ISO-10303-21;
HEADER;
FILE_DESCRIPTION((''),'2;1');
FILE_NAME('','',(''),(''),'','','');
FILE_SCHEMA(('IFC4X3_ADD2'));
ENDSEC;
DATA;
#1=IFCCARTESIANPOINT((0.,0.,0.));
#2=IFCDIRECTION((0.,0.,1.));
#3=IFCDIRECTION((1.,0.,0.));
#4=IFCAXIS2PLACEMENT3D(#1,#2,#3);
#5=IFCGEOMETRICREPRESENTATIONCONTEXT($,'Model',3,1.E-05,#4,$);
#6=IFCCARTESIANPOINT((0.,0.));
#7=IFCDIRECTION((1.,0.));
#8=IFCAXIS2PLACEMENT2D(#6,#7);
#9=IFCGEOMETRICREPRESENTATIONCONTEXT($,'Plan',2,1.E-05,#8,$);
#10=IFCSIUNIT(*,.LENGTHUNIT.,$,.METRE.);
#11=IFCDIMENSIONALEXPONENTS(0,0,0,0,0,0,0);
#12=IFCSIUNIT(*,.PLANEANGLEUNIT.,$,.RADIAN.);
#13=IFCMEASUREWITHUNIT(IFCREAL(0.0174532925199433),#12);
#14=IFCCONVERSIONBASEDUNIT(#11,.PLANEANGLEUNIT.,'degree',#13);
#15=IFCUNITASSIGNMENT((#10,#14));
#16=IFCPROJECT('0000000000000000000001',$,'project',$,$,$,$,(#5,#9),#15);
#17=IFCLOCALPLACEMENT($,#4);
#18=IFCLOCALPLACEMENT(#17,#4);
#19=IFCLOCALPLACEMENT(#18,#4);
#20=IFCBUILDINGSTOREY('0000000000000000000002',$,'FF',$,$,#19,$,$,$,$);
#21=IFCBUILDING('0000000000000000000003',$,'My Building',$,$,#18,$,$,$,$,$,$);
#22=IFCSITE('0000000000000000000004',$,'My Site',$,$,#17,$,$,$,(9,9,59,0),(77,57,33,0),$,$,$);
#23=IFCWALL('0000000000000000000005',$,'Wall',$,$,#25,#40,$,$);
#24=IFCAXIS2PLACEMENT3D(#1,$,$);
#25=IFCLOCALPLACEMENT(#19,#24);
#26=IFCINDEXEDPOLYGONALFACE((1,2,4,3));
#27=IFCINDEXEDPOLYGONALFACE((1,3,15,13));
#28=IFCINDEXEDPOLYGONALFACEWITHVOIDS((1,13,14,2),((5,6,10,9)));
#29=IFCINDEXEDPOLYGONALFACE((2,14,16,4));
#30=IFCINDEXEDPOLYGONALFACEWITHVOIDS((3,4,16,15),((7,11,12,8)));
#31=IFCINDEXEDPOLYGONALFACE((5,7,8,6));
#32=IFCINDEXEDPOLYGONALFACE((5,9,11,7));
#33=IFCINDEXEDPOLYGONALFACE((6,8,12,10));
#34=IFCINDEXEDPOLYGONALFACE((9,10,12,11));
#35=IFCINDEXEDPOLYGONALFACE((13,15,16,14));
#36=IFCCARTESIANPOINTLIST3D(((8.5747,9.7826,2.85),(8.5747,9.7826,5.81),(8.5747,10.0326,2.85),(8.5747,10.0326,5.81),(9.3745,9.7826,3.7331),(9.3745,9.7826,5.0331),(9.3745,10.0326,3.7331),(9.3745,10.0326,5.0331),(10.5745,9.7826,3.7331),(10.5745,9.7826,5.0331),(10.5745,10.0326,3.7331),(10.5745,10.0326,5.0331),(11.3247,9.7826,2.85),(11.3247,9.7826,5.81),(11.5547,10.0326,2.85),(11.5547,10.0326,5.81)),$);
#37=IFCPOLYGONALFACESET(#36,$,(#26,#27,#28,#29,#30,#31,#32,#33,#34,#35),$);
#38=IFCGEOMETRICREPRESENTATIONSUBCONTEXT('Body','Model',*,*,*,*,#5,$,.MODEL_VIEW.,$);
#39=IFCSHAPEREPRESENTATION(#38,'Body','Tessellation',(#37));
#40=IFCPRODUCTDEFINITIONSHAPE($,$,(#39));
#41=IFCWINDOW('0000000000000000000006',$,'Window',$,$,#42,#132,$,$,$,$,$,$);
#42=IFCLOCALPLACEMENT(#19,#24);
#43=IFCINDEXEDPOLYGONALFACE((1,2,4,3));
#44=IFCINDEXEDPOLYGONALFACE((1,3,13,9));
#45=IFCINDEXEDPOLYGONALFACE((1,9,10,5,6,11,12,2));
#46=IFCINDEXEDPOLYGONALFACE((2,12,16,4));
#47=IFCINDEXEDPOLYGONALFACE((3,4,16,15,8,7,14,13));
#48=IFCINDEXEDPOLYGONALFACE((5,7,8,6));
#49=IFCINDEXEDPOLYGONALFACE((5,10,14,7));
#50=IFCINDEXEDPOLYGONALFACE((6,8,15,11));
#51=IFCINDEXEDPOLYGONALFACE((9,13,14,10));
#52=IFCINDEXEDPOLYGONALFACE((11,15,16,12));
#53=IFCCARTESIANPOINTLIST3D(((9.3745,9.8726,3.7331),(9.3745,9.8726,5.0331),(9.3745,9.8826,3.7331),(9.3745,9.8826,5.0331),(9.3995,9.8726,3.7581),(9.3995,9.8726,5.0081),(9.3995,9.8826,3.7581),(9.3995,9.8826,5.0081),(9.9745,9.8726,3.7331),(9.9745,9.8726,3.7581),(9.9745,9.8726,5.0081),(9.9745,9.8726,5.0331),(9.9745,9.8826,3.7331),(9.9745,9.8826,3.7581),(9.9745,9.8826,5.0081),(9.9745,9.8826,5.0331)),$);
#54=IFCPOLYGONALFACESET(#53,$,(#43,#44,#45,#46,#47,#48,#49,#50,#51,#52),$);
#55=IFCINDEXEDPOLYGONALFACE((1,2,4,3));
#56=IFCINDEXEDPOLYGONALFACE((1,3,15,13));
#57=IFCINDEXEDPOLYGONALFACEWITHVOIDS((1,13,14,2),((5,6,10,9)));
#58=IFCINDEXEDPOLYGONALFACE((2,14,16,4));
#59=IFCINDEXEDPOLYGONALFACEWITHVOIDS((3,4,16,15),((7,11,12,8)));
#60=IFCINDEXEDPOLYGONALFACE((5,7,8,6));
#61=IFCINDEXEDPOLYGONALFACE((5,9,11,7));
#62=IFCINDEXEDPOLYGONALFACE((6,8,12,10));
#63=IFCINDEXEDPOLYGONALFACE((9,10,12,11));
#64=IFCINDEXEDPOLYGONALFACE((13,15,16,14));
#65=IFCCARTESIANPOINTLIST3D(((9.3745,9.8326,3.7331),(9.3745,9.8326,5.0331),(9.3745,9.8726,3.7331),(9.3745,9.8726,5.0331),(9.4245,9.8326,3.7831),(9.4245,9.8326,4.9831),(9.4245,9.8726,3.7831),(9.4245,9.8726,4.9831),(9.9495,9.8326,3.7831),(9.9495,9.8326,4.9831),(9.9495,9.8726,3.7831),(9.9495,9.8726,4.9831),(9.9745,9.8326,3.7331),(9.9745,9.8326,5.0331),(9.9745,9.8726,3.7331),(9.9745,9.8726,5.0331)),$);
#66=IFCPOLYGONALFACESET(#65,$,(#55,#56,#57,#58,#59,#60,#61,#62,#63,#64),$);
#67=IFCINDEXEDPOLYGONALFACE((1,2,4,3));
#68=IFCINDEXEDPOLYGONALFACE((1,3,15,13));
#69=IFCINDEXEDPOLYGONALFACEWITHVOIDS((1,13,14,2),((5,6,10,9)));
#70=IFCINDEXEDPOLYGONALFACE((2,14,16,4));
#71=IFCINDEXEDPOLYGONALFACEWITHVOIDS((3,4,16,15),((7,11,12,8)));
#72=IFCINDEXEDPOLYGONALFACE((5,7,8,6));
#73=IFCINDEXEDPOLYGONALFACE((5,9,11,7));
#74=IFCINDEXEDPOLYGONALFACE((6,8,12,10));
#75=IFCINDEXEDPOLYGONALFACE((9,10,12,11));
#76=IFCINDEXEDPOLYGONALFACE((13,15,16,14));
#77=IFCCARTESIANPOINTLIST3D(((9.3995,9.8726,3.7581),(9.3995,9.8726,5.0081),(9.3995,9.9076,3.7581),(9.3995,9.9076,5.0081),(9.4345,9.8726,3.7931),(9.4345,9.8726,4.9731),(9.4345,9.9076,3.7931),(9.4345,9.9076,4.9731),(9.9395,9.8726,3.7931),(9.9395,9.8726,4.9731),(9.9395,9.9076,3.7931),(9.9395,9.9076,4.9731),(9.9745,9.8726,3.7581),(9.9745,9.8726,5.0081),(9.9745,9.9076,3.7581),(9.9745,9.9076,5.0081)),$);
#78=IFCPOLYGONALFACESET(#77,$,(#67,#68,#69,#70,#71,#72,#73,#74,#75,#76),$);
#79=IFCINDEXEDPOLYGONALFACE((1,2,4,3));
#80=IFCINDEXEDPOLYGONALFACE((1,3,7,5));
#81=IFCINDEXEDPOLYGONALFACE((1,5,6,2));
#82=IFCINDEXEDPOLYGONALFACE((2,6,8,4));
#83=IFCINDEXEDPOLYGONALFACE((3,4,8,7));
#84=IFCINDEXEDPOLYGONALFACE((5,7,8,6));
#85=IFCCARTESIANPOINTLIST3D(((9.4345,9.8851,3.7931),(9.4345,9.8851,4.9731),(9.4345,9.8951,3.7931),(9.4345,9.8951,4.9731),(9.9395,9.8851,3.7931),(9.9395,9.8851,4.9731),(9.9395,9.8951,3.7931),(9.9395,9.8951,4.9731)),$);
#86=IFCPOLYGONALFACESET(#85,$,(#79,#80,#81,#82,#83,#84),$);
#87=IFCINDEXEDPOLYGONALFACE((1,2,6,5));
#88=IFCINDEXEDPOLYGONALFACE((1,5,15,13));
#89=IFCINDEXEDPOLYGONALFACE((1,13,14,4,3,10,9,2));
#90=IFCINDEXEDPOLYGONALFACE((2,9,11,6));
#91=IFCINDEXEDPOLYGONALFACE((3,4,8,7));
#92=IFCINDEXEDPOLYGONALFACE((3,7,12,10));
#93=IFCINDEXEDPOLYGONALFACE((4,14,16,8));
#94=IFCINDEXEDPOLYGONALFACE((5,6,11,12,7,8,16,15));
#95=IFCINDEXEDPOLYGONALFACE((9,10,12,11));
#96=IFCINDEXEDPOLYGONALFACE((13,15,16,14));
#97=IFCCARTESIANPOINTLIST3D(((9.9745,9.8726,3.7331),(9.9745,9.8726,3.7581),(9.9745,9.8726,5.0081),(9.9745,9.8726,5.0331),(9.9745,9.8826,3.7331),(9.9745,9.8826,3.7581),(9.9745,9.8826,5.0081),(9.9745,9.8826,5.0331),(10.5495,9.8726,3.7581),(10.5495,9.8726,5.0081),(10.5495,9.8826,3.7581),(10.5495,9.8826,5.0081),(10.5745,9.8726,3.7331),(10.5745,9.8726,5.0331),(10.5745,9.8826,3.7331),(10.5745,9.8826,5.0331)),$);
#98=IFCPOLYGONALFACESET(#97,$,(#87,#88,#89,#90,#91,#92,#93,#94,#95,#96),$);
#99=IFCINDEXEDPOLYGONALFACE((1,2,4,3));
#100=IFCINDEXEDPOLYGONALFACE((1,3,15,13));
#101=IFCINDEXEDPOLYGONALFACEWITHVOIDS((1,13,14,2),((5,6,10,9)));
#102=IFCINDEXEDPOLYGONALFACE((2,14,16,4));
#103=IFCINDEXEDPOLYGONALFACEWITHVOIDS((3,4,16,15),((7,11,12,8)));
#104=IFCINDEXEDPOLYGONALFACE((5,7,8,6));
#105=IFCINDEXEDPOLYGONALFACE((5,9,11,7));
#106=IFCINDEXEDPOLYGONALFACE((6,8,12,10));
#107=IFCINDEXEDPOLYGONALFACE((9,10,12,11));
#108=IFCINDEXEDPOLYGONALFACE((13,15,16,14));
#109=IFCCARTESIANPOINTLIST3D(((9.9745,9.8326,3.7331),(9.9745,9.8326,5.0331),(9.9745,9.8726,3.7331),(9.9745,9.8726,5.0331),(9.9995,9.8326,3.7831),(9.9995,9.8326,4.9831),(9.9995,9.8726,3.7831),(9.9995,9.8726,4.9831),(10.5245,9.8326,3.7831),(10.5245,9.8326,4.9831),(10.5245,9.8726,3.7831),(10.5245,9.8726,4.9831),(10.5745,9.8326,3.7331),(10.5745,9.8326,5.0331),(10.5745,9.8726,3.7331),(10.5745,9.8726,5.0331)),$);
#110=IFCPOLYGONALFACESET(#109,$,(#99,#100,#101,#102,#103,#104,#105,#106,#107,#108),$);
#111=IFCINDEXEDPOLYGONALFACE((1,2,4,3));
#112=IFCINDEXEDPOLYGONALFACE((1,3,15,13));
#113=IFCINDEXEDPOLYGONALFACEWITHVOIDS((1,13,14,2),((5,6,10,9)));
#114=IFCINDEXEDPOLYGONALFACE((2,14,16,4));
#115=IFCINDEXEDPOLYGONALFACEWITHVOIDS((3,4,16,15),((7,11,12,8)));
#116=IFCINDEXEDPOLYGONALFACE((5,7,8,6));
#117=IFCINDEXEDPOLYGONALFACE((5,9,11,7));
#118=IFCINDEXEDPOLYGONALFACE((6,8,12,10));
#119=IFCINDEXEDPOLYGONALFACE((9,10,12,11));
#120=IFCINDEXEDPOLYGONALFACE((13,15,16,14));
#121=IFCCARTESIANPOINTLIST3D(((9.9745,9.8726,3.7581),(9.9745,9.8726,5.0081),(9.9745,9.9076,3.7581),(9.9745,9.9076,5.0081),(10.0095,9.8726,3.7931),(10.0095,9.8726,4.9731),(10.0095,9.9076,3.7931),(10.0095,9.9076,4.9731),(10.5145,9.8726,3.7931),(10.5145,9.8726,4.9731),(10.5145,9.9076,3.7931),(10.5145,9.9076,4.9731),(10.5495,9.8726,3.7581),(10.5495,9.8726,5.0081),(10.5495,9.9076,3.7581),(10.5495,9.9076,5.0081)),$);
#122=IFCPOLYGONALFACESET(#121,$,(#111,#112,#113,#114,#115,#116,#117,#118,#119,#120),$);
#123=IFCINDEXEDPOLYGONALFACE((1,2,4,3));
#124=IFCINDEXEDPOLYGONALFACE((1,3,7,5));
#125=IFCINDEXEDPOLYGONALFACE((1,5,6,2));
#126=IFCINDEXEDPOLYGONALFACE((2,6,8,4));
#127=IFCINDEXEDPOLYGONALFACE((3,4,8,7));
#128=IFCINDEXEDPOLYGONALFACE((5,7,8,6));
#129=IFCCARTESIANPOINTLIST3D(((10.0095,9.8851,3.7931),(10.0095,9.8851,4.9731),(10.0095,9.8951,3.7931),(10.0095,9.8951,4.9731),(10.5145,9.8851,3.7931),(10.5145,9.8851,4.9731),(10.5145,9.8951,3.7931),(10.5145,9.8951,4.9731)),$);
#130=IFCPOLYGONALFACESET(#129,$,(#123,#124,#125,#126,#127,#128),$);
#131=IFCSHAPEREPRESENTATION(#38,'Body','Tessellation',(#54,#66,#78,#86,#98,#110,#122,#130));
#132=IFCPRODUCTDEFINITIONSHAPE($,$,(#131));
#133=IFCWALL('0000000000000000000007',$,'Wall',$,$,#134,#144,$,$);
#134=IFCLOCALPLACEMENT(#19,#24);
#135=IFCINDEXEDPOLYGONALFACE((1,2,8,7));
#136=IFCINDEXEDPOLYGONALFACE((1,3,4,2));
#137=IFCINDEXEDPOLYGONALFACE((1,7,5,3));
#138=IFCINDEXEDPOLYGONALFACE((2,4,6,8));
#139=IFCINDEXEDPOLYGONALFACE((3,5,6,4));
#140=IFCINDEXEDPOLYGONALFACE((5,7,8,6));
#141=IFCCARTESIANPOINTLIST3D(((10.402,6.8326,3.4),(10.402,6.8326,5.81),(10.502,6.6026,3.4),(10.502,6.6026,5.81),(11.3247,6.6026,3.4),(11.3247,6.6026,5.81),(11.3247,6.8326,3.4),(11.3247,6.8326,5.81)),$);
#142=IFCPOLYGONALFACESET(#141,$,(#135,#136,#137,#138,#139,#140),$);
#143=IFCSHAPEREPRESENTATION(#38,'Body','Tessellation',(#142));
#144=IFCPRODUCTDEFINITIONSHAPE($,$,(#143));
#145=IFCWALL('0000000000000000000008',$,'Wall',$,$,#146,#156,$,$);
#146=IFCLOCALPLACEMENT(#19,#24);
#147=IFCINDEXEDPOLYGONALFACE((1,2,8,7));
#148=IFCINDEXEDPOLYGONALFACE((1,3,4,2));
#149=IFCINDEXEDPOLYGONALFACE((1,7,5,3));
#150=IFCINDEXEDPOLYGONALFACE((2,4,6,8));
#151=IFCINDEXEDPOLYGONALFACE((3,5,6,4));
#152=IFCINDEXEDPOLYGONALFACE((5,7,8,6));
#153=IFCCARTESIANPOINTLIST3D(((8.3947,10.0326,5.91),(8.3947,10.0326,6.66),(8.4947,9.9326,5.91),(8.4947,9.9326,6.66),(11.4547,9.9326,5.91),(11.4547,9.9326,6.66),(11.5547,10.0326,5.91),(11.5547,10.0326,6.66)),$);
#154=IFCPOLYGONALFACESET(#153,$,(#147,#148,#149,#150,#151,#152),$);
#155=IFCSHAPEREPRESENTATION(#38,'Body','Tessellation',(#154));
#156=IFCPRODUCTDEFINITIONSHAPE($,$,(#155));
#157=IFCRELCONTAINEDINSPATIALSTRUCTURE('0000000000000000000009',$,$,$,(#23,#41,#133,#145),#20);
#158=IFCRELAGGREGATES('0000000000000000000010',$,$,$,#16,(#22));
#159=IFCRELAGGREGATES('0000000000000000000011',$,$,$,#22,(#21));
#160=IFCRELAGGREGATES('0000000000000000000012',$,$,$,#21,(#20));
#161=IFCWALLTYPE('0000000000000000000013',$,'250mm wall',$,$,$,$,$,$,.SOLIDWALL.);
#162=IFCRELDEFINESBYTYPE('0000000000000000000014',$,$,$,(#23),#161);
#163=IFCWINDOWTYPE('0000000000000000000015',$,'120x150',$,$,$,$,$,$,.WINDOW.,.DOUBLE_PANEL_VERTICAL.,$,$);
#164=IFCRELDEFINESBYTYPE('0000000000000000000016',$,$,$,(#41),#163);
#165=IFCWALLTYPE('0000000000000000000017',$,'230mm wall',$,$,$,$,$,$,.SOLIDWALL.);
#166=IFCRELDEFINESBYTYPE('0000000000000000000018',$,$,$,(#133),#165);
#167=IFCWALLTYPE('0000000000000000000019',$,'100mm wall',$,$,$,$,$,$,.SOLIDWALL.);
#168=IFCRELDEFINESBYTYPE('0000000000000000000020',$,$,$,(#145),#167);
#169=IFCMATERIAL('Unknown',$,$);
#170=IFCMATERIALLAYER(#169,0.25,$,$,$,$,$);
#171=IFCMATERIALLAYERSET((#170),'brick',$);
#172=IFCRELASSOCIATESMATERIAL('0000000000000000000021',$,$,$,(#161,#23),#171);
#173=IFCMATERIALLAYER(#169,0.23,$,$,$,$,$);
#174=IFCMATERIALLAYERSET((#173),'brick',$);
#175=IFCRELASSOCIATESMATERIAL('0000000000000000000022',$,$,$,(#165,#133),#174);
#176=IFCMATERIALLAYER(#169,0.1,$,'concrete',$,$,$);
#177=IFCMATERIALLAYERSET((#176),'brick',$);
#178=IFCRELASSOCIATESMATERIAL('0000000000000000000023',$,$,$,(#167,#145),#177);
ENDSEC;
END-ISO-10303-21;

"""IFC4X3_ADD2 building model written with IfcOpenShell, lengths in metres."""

from ifc_helpers import new_model, entity, si_unit, converted_unit, frame, origin_with_axes, origin_2d_with_axis, place, context, subcontext, project, spatial, line, indexed_curve, outline, extrude, shape, source, transform, mapped, material, layer, layer_set, layer_usage, type_object, type_shapes, element, fill, save


model = new_model("IFC4X3_ADD2")

# Units and contexts
model_context = context("Model", 3, precision=1e-05, world=origin_with_axes())
plan_context = context("Plan", 2, precision=1e-05, world=origin_2d_with_axis())
body_context_1 = subcontext(model_context, "Body", "Model", "MODEL_VIEW")
body_context_2 = subcontext(plan_context, "Body", "Plan", "PLAN_VIEW")
ifc_project = project(units=[si_unit("LENGTHUNIT", "METRE"), converted_unit("PLANEANGLEUNIT", "degree", entity("IfcReal", 0.0174532925199433), si_unit("PLANEANGLEUNIT", "RADIAN"), dimensions=[0, 0, 0, 0, 0, 0, 0])], contexts=[model_context, plan_context])

# Site, building, storey
site_placement = place(None, origin_with_axes())
site = spatial("IfcSite", under=ifc_project, at=site_placement, Name="My Site", RefLatitude=(9, 9, 59, 0), RefLongitude=(77, 57, 33, 0))
building_placement = place(site_placement, origin_with_axes())
building = spatial("IfcBuilding", under=site, at=building_placement, Name="My Building")
storey_placement = place(building_placement, origin_with_axes())
storey = spatial("IfcBuildingStorey", under=building, at=storey_placement, Name="FF")

# Shared definitions
ifc_material = material(Name="Unknown")

# Wall, opening, window
ifc_layer_1 = layer(ifc_material, 0.25)
ifc_layer_set_1 = layer_set([ifc_layer_1], Name="brick")
ifc_layer_usage_1 = layer_usage(ifc_layer_set_1, "AXIS2", "POSITIVE", 0.0)
wall_type_1 = type_object("IfcWallType", Name="250mm wall", PredefinedType="SOLIDWALL", material=ifc_layer_set_1)
wall_1_placement = place(storey_placement, frame((8.5747, 9.7826, 2.85), z_axis=(0.0, 0.0, 1.0), x_axis=(1.0, 0.0, 0.0)))
wall_1 = element("IfcWall", 1, at=wall_1_placement, inside=storey, type_object=wall_type_1, material=ifc_layer_usage_1, Name="Wall", context=body_context_1, shape_type="SweptSolid", body=[
    extrude(outline(indexed_curve([(0.0, 0.0), (0.0, 0.25), (2.98, 0.25), (2.75, 0.0)], segments=[line(1, 2, 3, 4, 1)])), origin_with_axes(), (0.0, 0.0, 1.0), 2.96),
])
shared_shape_1 = source(origin_with_axes(), body_context_1, "Body", "SweptSolid", [
    extrude(outline(indexed_curve([(0.0, 0.0), (1.2, 0.0), (1.2, 1.3), (0.0, 1.3)], segments=[line(1, 2, 3, 4, 1)])), frame((0.0, -0.6, 0.0), z_axis=(0.0, -1.0, 0.0), x_axis=(1.0, 0.0, 0.0)), (0.0, 0.0, -1.0), 1.2),
])
opening_1_placement = place(wall_1_placement, frame((0.7998, 0.0, 0.8831), z_axis=(0.0, 0.0, 1.0), x_axis=(1.0, 0.0, 0.0)))
opening_1 = element("IfcOpeningElement", 2, at=opening_1_placement, cuts=wall_1, PredefinedType="OPENING", context=body_context_1, shape_type="MappedRepresentation", body=[
    mapped(shared_shape_1, transform((0.0, 0.0, 0.0), x_axis=(1.0, 0.0, 0.0), y_axis=(0.0, 1.0, 0.0), z_axis=(0.0, 0.0, 1.0), scale=1.0)),
])
window_type = type_object("IfcWindowType", Name="120x150", PartitioningType="DOUBLE_PANEL_VERTICAL", PredefinedType="WINDOW")
shared_shape_2 = source(origin_with_axes(), body_context_1, "Body", "SweptSolid", [
    extrude(outline(indexed_curve([(0.6, 0.0), (0.0, 0.0), (0.0, 1.3), (0.6, 1.3), (0.6, 1.275), (0.025, 1.275), (0.025, 0.025), (0.6, 0.025)], segments=[line(1, 2, 3, 4, 5, 6, 7, 8, 1)])), frame((0.0, 0.09, 0.0), z_axis=(0.0, -1.0, 0.0), x_axis=(1.0, 0.0, 0.0)), (0.0, 0.0, -1.0), 0.01),
    extrude(outline(indexed_curve([(0.0, 0.0), (0.6, 0.0), (0.6, 1.3), (0.0, 1.3)], segments=[line(1, 2, 3, 4, 1)]), holes=[indexed_curve([(0.05, 0.05), (0.575, 0.05), (0.575, 1.25), (0.05, 1.25)], segments=[line(1, 2, 3, 4, 1)])]), frame((0.0, 0.05, 0.0), z_axis=(0.0, -1.0, 0.0), x_axis=(1.0, 0.0, 0.0)), (0.0, 0.0, -1.0), 0.04),
    extrude(outline(indexed_curve([(0.0, 0.0), (0.575, 0.0), (0.575, 1.25), (0.0, 1.25)], segments=[line(1, 2, 3, 4, 1)]), holes=[indexed_curve([(0.035, 0.035), (0.54, 0.035), (0.54, 1.215), (0.035, 1.215)], segments=[line(1, 2, 3, 4, 1)])]), frame((0.025, 0.09, 0.025), z_axis=(0.0, -1.0, 0.0), x_axis=(1.0, 0.0, 0.0)), (0.0, 0.0, -1.0), 0.035),
    extrude(outline(indexed_curve([(0.035, 0.035), (0.54, 0.035), (0.54, 1.215), (0.035, 1.215)], segments=[line(1, 2, 3, 4, 1)])), frame((0.025, 0.1025, 0.025), z_axis=(0.0, -1.0, 0.0), x_axis=(1.0, 0.0, 0.0)), (0.0, 0.0, -1.0), 0.01),
    extrude(outline(indexed_curve([(0.0, 1.3), (0.6, 1.3), (0.6, 0.0), (0.0, 0.0), (0.0, 0.025), (0.575, 0.025), (0.575, 1.275), (0.0, 1.275)], segments=[line(1, 2, 3, 4, 5, 6, 7, 8, 1)])), frame((0.6, 0.09, 0.0), z_axis=(0.0, -1.0, 0.0), x_axis=(1.0, 0.0, 0.0)), (0.0, 0.0, -1.0), 0.01),
    extrude(outline(indexed_curve([(0.0, 0.0), (0.6, 0.0), (0.6, 1.3), (0.0, 1.3)], segments=[line(1, 2, 3, 4, 1)]), holes=[indexed_curve([(0.025, 0.05), (0.55, 0.05), (0.55, 1.25), (0.025, 1.25)], segments=[line(1, 2, 3, 4, 1)])]), frame((0.6, 0.05, 0.0), z_axis=(0.0, -1.0, 0.0), x_axis=(1.0, 0.0, 0.0)), (0.0, 0.0, -1.0), 0.04),
    extrude(outline(indexed_curve([(0.0, 0.0), (0.575, 0.0), (0.575, 1.25), (0.0, 1.25)], segments=[line(1, 2, 3, 4, 1)]), holes=[indexed_curve([(0.035, 0.035), (0.54, 0.035), (0.54, 1.215), (0.035, 1.215)], segments=[line(1, 2, 3, 4, 1)])]), frame((0.6, 0.09, 0.025), z_axis=(0.0, -1.0, 0.0), x_axis=(1.0, 0.0, 0.0)), (0.0, 0.0, -1.0), 0.035),
    extrude(outline(indexed_curve([(0.035, 0.035), (0.54, 0.035), (0.54, 1.215), (0.035, 1.215)], segments=[line(1, 2, 3, 4, 1)])), frame((0.6, 0.1025, 0.025), z_axis=(0.0, -1.0, 0.0), x_axis=(1.0, 0.0, 0.0)), (0.0, 0.0, -1.0), 0.01),
])
shared_shape_3 = source(origin_with_axes(), body_context_2, "Body", "Curve2D", [
    entity("IfcIndexedPolyCurve", entity("IfcCartesianPointList2D", [[0.05, 0.05], [0.575, 0.05]])),
    entity("IfcIndexedPolyCurve", entity("IfcCartesianPointList2D", [[0.0, 0.1], [0.025, 0.1], [0.025, 0.09], [0.05, 0.09], [0.05, 0.05], [0.0, 0.05]]), [entity("IfcLineIndex", [1, 2, 3, 4, 5, 6, 1])]),
    entity("IfcIndexedPolyCurve", entity("IfcCartesianPointList2D", [[0.6, 0.1], [0.6, 0.1], [0.6, 0.09], [0.575, 0.09], [0.575, 0.05], [0.6, 0.05]])),
    entity("IfcIndexedPolyCurve", entity("IfcCartesianPointList2D", [[0.025, 0.09], [0.06, 0.09], [0.06, 0.125], [0.025, 0.125]]), [entity("IfcLineIndex", [1, 2, 3, 4, 1])]),
    entity("IfcIndexedPolyCurve", entity("IfcCartesianPointList2D", [[0.6, 0.09], [0.565, 0.09], [0.565, 0.125], [0.6, 0.125]]), [entity("IfcLineIndex", [1, 2, 3, 4, 1])]),
    entity("IfcIndexedPolyCurve", entity("IfcCartesianPointList2D", [[0.06, 0.09], [0.565, 0.09]])),
    entity("IfcIndexedPolyCurve", entity("IfcCartesianPointList2D", [[0.06, 0.125], [0.565, 0.125]])),
    entity("IfcIndexedPolyCurve", entity("IfcCartesianPointList2D", [[0.06, 0.1075], [0.565, 0.1075]])),
    entity("IfcIndexedPolyCurve", entity("IfcCartesianPointList2D", [[0.625, 0.05], [1.15, 0.05]])),
    entity("IfcIndexedPolyCurve", entity("IfcCartesianPointList2D", [[0.6, 0.1], [0.6, 0.1], [0.6, 0.09], [0.625, 0.09], [0.625, 0.05], [0.6, 0.05]])),
    entity("IfcIndexedPolyCurve", entity("IfcCartesianPointList2D", [[1.2, 0.1], [1.175, 0.1], [1.175, 0.09], [1.15, 0.09], [1.15, 0.05], [1.2, 0.05]]), [entity("IfcLineIndex", [1, 2, 3, 4, 5, 6, 1])]),
    entity("IfcIndexedPolyCurve", entity("IfcCartesianPointList2D", [[0.6, 0.09], [0.635, 0.09], [0.635, 0.125], [0.6, 0.125]]), [entity("IfcLineIndex", [1, 2, 3, 4, 1])]),
    entity("IfcIndexedPolyCurve", entity("IfcCartesianPointList2D", [[1.175, 0.09], [1.14, 0.09], [1.14, 0.125], [1.175, 0.125]]), [entity("IfcLineIndex", [1, 2, 3, 4, 1])]),
    entity("IfcIndexedPolyCurve", entity("IfcCartesianPointList2D", [[0.635, 0.09], [1.14, 0.09]])),
    entity("IfcIndexedPolyCurve", entity("IfcCartesianPointList2D", [[0.635, 0.125], [1.14, 0.125]])),
    entity("IfcIndexedPolyCurve", entity("IfcCartesianPointList2D", [[0.635, 0.1075], [1.14, 0.1075]])),
])
type_shapes(window_type, [shared_shape_2, shared_shape_3])
window_placement = place(opening_1_placement, origin_with_axes())
window = element("IfcWindow", 3, at=window_placement, inside=storey, type_object=window_type, Name="Window", shapes=[
    shape(body_context_1, "Body", "MappedRepresentation", [mapped(shared_shape_2, transform((0.0, 0.0, 0.0), x_axis=(1.0, 0.0, 0.0), y_axis=(0.0, 1.0, 0.0), z_axis=(0.0, 0.0, 1.0), scale=1.0))]),
    shape(body_context_2, "Body", "MappedRepresentation", [mapped(shared_shape_3, transform((0.0, 0.0, 0.0), x_axis=(1.0, 0.0, 0.0), y_axis=(0.0, 1.0, 0.0), z_axis=(0.0, 0.0, 1.0), scale=1.0))]),
])
fill(opening_1, window)

# Walls
ifc_layer_2 = layer(ifc_material, 0.23)
ifc_layer_set_2 = layer_set([ifc_layer_2], Name="brick")
ifc_layer_usage_2 = layer_usage(ifc_layer_set_2, "AXIS2", "POSITIVE", 0.0)
wall_type_2 = type_object("IfcWallType", Name="230mm wall", PredefinedType="SOLIDWALL", material=ifc_layer_set_2)
wall_2_placement = place(storey_placement, frame((11.3247, 6.8326, 3.4), z_axis=(0.0, 0.0, 1.0), x_axis=(-1.0, 0.0, 0.0)))
element("IfcWall", 4, at=wall_2_placement, inside=storey, type_object=wall_type_2, material=ifc_layer_usage_2, Name="Wall", context=body_context_1, shape_type="SweptSolid", body=[
    extrude(outline(indexed_curve([(0.0, 0.0), (0.0, 0.23), (0.8226, 0.23), (0.9226, 0.0)], segments=[line(1, 2, 3, 4, 1)])), origin_with_axes(), (0.0, 0.0, 1.0), 2.41),
])
ifc_layer_3 = layer(ifc_material, 0.1, Name="concrete")
ifc_layer_set_3 = layer_set([ifc_layer_3], Name="brick")
ifc_layer_usage_3 = layer_usage(ifc_layer_set_3, "AXIS2", "POSITIVE", 0.0)
wall_type_3 = type_object("IfcWallType", Name="100mm wall", PredefinedType="SOLIDWALL", material=ifc_layer_set_3)
wall_3_placement = place(storey_placement, frame((11.5547, 10.0326, 5.91), z_axis=(0.0, 0.0, 1.0), x_axis=(-1.0, 0.0, 0.0)))
element("IfcWall", 5, at=wall_3_placement, inside=storey, type_object=wall_type_3, material=ifc_layer_usage_3, Name="Wall", context=body_context_1, shape_type="SweptSolid", body=[
    extrude(outline(indexed_curve([(0.0, 0.0), (0.1, 0.1), (3.06, 0.1), (3.16, 0.0)], segments=[line(1, 2, 3, 4, 1)])), origin_with_axes(), (0.0, 0.0, 1.0), 0.75),
])

save(model, "model.ifc")
